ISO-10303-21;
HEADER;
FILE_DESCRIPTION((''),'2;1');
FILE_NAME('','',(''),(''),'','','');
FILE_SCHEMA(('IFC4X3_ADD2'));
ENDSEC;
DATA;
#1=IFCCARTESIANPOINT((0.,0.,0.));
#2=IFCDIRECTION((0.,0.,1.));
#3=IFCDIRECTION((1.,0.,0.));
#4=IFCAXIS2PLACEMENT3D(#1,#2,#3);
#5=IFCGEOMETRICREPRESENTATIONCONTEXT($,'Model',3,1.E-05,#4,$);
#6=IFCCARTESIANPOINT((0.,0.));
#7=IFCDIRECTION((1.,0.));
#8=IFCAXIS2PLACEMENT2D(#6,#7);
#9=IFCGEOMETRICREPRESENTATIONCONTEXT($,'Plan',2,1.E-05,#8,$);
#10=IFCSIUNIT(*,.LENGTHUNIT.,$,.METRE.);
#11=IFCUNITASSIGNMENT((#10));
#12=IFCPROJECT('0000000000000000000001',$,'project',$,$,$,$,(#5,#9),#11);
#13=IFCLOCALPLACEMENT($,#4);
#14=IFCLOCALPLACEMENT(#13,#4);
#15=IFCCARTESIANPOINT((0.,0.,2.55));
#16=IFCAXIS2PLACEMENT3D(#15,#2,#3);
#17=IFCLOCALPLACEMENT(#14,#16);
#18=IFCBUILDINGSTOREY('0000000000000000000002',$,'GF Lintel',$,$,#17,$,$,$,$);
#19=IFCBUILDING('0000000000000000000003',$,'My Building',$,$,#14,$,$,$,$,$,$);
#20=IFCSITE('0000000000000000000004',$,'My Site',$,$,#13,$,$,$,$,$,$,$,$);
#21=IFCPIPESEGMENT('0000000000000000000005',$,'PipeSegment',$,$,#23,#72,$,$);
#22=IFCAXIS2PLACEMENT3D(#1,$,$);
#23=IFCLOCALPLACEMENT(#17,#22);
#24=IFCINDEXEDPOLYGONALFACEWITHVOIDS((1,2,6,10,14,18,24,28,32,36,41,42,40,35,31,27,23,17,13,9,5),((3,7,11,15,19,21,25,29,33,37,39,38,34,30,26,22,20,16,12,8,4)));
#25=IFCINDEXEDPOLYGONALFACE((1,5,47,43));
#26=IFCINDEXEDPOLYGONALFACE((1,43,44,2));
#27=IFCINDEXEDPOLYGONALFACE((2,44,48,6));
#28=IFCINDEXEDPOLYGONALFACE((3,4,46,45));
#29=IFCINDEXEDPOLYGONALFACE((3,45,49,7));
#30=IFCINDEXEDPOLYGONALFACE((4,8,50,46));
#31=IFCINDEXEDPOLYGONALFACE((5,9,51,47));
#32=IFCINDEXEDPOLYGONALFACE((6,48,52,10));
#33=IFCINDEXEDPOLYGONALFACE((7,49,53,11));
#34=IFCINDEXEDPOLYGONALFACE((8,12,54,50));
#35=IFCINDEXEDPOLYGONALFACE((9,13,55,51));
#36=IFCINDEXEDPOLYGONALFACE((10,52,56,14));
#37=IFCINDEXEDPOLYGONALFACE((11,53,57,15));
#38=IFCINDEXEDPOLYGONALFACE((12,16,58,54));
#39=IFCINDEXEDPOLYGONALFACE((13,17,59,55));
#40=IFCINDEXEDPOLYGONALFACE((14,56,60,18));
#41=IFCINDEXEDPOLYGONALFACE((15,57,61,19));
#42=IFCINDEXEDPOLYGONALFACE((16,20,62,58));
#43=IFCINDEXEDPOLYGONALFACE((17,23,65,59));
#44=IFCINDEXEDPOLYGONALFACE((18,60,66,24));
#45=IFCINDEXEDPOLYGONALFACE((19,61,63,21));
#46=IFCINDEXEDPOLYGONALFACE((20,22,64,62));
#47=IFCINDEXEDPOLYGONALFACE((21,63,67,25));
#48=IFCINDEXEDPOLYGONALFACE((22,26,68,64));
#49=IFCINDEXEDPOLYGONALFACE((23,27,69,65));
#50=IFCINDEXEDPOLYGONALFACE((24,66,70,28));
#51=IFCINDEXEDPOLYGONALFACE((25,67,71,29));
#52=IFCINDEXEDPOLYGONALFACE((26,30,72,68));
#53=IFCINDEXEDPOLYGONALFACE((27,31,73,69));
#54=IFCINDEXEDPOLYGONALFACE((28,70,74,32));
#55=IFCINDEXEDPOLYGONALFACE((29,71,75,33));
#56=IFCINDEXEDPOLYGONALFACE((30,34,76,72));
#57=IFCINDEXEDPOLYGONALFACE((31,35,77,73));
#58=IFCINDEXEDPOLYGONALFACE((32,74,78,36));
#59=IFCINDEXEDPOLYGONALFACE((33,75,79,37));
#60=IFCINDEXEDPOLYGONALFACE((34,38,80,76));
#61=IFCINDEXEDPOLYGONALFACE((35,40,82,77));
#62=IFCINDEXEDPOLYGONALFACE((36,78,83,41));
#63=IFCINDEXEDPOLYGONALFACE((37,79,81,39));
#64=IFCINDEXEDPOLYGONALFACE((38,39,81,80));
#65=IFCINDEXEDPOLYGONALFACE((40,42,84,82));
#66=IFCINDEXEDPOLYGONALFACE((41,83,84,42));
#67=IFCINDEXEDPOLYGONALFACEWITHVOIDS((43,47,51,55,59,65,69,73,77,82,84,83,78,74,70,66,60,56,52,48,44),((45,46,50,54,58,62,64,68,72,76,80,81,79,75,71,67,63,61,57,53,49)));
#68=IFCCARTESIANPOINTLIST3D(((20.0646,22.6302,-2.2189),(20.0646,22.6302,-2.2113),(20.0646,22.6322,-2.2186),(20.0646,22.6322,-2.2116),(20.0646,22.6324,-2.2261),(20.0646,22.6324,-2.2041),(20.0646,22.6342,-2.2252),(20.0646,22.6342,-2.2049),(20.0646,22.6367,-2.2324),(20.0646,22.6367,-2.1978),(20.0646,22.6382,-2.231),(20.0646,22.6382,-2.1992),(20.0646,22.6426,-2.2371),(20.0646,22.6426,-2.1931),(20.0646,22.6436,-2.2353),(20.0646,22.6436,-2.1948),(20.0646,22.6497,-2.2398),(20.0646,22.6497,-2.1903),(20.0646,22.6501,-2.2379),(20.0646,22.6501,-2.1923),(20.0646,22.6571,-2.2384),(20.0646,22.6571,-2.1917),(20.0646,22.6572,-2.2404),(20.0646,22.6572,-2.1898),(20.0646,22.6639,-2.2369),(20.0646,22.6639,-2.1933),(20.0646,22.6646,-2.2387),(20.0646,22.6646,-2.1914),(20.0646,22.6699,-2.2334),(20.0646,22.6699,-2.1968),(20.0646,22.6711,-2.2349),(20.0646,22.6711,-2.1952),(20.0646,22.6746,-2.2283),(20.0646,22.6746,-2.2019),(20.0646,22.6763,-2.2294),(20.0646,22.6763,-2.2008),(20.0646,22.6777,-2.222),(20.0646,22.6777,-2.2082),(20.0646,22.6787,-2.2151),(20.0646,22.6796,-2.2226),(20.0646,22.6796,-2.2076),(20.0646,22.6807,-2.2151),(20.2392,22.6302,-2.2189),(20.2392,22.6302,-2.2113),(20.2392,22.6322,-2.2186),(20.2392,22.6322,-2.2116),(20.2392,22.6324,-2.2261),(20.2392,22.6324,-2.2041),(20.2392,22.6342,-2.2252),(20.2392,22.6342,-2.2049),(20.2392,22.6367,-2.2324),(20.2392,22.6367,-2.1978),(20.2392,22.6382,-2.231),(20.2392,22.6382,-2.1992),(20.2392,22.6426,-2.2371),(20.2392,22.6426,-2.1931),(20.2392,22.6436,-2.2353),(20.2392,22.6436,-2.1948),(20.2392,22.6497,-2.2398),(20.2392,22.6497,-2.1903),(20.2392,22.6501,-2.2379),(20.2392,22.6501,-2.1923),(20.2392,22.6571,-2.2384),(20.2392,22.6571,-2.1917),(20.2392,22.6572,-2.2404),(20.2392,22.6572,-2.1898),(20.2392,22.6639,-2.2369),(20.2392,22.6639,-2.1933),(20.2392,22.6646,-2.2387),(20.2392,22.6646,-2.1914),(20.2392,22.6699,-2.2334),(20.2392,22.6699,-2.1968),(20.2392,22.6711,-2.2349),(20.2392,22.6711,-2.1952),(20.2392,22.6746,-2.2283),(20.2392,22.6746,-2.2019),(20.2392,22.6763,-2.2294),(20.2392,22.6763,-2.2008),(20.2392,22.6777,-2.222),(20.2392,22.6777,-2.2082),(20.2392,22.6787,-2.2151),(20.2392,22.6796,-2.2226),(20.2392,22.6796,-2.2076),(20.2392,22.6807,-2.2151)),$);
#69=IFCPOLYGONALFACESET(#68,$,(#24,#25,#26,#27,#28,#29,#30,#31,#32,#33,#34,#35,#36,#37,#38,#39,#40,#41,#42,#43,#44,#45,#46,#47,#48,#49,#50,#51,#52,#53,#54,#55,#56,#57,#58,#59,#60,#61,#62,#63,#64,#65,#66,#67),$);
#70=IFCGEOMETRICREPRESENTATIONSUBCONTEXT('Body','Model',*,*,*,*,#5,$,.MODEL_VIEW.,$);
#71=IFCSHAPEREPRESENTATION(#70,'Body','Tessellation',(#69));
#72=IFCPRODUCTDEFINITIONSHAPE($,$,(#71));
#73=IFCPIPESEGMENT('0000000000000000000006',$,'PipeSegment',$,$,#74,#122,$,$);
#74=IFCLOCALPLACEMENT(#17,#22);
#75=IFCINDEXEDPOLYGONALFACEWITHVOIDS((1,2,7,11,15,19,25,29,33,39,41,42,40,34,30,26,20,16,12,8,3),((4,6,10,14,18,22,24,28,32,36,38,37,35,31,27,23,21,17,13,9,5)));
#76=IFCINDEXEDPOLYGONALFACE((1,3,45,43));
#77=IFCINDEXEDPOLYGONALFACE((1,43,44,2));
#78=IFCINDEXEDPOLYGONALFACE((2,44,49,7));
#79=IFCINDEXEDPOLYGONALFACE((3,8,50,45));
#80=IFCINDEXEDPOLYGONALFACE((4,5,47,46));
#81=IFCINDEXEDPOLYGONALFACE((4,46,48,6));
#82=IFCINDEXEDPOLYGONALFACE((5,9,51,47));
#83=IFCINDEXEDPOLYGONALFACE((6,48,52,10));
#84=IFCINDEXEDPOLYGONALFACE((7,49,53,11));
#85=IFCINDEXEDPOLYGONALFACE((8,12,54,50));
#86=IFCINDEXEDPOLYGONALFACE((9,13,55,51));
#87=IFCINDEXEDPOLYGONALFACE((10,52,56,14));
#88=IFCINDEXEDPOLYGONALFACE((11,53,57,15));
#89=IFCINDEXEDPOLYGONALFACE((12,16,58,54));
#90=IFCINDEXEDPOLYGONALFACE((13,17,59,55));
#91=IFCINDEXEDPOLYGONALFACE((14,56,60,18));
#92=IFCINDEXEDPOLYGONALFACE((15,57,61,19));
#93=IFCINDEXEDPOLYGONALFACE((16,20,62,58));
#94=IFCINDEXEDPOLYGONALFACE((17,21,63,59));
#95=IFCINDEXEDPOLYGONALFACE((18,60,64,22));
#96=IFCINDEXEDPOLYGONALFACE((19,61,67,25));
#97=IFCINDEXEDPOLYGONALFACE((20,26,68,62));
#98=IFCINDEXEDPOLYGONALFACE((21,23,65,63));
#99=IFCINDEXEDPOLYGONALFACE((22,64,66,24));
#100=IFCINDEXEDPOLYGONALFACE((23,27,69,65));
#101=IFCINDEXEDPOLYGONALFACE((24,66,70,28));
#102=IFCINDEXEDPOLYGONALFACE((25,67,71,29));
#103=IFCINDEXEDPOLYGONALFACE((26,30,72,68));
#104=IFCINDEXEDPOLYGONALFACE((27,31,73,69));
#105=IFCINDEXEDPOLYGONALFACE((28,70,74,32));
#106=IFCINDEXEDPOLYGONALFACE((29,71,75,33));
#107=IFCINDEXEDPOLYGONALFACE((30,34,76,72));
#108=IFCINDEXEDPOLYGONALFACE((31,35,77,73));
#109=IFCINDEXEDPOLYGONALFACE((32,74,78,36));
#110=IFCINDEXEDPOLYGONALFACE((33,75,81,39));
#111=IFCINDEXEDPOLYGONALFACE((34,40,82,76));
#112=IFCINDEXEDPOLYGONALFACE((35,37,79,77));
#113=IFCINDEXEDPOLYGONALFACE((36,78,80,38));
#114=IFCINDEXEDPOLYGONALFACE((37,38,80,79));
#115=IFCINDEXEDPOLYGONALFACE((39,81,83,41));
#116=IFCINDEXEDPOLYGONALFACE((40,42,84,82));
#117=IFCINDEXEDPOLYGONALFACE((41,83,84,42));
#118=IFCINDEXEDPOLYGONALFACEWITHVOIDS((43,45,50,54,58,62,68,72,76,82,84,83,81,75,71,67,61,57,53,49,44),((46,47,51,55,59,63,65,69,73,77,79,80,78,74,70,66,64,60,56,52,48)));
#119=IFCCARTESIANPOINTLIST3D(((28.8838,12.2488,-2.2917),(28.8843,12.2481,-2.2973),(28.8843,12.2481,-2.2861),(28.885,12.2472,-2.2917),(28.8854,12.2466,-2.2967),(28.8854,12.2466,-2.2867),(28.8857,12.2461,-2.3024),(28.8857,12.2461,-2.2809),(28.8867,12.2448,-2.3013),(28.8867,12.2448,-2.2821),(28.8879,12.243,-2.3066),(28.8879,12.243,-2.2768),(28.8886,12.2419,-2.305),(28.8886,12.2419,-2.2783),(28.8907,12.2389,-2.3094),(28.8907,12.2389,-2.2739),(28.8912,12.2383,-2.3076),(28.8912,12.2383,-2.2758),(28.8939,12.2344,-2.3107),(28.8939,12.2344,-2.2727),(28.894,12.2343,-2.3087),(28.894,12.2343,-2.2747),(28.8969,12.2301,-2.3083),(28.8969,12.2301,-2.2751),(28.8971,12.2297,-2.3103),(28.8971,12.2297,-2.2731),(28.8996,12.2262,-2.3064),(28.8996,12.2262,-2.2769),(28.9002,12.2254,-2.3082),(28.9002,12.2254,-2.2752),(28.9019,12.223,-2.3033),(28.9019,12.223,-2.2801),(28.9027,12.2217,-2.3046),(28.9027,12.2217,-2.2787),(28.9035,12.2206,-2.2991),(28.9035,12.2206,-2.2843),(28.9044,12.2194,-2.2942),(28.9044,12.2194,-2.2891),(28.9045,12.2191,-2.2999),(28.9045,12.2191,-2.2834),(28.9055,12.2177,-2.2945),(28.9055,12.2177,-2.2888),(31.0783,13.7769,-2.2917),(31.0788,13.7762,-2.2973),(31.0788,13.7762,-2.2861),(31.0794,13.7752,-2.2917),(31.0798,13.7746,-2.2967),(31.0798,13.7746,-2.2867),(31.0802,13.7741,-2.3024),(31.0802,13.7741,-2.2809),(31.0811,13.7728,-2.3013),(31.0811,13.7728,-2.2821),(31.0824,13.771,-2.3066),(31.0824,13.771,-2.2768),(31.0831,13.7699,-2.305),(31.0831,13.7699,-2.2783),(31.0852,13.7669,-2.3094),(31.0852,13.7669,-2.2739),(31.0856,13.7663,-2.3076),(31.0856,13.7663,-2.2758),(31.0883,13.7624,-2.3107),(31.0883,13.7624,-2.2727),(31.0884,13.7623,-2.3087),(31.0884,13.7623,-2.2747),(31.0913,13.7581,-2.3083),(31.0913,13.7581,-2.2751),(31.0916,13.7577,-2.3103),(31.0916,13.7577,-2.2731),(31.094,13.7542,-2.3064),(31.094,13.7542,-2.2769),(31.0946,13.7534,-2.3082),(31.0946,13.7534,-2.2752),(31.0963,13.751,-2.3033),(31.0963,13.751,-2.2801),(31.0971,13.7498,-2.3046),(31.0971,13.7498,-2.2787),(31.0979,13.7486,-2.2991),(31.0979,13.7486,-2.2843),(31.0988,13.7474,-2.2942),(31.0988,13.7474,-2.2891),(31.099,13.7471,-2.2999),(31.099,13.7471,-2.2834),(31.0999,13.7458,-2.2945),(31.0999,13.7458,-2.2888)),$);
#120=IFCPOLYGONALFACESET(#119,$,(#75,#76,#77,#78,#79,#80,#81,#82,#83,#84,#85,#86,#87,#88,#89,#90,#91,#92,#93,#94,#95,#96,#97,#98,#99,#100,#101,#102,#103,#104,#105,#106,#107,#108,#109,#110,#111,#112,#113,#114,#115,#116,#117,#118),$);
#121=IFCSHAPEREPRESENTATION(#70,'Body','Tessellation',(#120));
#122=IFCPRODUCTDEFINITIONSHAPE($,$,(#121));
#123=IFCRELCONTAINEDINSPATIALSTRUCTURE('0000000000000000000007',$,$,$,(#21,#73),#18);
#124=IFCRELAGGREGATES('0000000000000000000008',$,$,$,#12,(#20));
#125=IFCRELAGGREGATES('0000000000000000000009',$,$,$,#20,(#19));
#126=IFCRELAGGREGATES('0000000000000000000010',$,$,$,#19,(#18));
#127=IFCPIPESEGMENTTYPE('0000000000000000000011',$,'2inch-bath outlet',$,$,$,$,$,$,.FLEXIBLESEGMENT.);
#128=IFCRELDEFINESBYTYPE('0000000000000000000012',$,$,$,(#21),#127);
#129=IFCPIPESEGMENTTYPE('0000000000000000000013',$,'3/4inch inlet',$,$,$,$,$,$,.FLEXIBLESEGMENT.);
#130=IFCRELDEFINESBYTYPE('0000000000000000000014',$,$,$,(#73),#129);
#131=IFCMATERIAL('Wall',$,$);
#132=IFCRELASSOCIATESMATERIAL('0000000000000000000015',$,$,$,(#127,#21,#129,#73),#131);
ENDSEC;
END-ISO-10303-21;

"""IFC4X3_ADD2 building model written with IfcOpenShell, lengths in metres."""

from ifc_helpers import new_model, si_unit, frame, origin_with_axes, origin_2d_with_axis, place, context, subcontext, project, spatial, hollow_circle, extrude, material, material_profile, profile_set, profile_usage, type_object, element, save


model = new_model("IFC4X3_ADD2")

# Units and contexts
model_context = context("Model", 3, precision=1e-05, world=origin_with_axes())
plan_context = context("Plan", 2, precision=1e-05, world=origin_2d_with_axis())
body_context = subcontext(model_context, "Body", "Model", "MODEL_VIEW")
ifc_project = project(units=[si_unit("LENGTHUNIT", "METRE")], contexts=[model_context, plan_context])

# Site, building, storey
site_placement = place(None, origin_with_axes())
site = spatial("IfcSite", under=ifc_project, at=site_placement, Name="My Site")
building_placement = place(site_placement, origin_with_axes())
building = spatial("IfcBuilding", under=site, at=building_placement, Name="My Building")
storey_placement = place(building_placement, frame((0.0, 0.0, 2.55), z_axis=(0.0, 0.0, 1.0), x_axis=(1.0, 0.0, 0.0)))
storey = spatial("IfcBuildingStorey", under=building, at=storey_placement, Name="GF Lintel")

# Shared definitions
ifc_material_1 = material(Name="Wall")

# Pipe segments
ifc_material_profile_1 = material_profile(ifc_material_1, hollow_circle(Radius=0.0254, WallThickness=0.002))
ifc_profile_set_1 = profile_set([ifc_material_profile_1], Name="graywater")
pipe_segment_type_1 = type_object("IfcPipeSegmentType", Name="2inch-bath outlet", PredefinedType="FLEXIBLESEGMENT", material=ifc_profile_set_1)
ifc_profile_usage_1 = profile_usage(ifc_profile_set_1, cardinal=5)
pipe_segment_1_placement = place(storey_placement, frame((20.0646, 22.6553, -2.2151), z_axis=(1.0, 0.0, 0.0), x_axis=(0.0, 1.0, 0.0)))
element("IfcPipeSegment", 1, at=pipe_segment_1_placement, inside=storey, type_object=pipe_segment_type_1, material=ifc_profile_usage_1, Name="PipeSegment", context=body_context, shape_type="SweptSolid", body=[
    extrude(hollow_circle(Radius=0.0254, WallThickness=0.002), origin_with_axes(), (0.0, 0.0, 1.0), 0.1746),
])
ifc_material_profile_2 = material_profile(ifc_material_1, hollow_circle(Radius=0.0191, WallThickness=0.002))
ifc_profile_set_2 = profile_set([ifc_material_profile_2], Name="coldwater")
ifc_profile_usage_2 = profile_usage(ifc_profile_set_2)
pipe_segment_type_2 = type_object("IfcPipeSegmentType", Name="3/4inch inlet", PredefinedType="FLEXIBLESEGMENT", material=ifc_profile_set_2)
pipe_segment_2_placement = place(storey_placement, frame((28.8947, 12.2332, -2.2917), z_axis=(0.820651, 0.57143, 0.0), x_axis=(-0.57143, 0.820651, 0.0)))
element("IfcPipeSegment", 2, at=pipe_segment_2_placement, inside=storey, type_object=pipe_segment_type_2, material=ifc_profile_usage_2, Name="PipeSegment", context=body_context, shape_type="SweptSolid", body=[
    extrude(hollow_circle(Radius=0.0191, WallThickness=0.002), origin_with_axes(), (0.0, 0.0, 1.0), 2.674),
])

save(model, "model.ifc")
